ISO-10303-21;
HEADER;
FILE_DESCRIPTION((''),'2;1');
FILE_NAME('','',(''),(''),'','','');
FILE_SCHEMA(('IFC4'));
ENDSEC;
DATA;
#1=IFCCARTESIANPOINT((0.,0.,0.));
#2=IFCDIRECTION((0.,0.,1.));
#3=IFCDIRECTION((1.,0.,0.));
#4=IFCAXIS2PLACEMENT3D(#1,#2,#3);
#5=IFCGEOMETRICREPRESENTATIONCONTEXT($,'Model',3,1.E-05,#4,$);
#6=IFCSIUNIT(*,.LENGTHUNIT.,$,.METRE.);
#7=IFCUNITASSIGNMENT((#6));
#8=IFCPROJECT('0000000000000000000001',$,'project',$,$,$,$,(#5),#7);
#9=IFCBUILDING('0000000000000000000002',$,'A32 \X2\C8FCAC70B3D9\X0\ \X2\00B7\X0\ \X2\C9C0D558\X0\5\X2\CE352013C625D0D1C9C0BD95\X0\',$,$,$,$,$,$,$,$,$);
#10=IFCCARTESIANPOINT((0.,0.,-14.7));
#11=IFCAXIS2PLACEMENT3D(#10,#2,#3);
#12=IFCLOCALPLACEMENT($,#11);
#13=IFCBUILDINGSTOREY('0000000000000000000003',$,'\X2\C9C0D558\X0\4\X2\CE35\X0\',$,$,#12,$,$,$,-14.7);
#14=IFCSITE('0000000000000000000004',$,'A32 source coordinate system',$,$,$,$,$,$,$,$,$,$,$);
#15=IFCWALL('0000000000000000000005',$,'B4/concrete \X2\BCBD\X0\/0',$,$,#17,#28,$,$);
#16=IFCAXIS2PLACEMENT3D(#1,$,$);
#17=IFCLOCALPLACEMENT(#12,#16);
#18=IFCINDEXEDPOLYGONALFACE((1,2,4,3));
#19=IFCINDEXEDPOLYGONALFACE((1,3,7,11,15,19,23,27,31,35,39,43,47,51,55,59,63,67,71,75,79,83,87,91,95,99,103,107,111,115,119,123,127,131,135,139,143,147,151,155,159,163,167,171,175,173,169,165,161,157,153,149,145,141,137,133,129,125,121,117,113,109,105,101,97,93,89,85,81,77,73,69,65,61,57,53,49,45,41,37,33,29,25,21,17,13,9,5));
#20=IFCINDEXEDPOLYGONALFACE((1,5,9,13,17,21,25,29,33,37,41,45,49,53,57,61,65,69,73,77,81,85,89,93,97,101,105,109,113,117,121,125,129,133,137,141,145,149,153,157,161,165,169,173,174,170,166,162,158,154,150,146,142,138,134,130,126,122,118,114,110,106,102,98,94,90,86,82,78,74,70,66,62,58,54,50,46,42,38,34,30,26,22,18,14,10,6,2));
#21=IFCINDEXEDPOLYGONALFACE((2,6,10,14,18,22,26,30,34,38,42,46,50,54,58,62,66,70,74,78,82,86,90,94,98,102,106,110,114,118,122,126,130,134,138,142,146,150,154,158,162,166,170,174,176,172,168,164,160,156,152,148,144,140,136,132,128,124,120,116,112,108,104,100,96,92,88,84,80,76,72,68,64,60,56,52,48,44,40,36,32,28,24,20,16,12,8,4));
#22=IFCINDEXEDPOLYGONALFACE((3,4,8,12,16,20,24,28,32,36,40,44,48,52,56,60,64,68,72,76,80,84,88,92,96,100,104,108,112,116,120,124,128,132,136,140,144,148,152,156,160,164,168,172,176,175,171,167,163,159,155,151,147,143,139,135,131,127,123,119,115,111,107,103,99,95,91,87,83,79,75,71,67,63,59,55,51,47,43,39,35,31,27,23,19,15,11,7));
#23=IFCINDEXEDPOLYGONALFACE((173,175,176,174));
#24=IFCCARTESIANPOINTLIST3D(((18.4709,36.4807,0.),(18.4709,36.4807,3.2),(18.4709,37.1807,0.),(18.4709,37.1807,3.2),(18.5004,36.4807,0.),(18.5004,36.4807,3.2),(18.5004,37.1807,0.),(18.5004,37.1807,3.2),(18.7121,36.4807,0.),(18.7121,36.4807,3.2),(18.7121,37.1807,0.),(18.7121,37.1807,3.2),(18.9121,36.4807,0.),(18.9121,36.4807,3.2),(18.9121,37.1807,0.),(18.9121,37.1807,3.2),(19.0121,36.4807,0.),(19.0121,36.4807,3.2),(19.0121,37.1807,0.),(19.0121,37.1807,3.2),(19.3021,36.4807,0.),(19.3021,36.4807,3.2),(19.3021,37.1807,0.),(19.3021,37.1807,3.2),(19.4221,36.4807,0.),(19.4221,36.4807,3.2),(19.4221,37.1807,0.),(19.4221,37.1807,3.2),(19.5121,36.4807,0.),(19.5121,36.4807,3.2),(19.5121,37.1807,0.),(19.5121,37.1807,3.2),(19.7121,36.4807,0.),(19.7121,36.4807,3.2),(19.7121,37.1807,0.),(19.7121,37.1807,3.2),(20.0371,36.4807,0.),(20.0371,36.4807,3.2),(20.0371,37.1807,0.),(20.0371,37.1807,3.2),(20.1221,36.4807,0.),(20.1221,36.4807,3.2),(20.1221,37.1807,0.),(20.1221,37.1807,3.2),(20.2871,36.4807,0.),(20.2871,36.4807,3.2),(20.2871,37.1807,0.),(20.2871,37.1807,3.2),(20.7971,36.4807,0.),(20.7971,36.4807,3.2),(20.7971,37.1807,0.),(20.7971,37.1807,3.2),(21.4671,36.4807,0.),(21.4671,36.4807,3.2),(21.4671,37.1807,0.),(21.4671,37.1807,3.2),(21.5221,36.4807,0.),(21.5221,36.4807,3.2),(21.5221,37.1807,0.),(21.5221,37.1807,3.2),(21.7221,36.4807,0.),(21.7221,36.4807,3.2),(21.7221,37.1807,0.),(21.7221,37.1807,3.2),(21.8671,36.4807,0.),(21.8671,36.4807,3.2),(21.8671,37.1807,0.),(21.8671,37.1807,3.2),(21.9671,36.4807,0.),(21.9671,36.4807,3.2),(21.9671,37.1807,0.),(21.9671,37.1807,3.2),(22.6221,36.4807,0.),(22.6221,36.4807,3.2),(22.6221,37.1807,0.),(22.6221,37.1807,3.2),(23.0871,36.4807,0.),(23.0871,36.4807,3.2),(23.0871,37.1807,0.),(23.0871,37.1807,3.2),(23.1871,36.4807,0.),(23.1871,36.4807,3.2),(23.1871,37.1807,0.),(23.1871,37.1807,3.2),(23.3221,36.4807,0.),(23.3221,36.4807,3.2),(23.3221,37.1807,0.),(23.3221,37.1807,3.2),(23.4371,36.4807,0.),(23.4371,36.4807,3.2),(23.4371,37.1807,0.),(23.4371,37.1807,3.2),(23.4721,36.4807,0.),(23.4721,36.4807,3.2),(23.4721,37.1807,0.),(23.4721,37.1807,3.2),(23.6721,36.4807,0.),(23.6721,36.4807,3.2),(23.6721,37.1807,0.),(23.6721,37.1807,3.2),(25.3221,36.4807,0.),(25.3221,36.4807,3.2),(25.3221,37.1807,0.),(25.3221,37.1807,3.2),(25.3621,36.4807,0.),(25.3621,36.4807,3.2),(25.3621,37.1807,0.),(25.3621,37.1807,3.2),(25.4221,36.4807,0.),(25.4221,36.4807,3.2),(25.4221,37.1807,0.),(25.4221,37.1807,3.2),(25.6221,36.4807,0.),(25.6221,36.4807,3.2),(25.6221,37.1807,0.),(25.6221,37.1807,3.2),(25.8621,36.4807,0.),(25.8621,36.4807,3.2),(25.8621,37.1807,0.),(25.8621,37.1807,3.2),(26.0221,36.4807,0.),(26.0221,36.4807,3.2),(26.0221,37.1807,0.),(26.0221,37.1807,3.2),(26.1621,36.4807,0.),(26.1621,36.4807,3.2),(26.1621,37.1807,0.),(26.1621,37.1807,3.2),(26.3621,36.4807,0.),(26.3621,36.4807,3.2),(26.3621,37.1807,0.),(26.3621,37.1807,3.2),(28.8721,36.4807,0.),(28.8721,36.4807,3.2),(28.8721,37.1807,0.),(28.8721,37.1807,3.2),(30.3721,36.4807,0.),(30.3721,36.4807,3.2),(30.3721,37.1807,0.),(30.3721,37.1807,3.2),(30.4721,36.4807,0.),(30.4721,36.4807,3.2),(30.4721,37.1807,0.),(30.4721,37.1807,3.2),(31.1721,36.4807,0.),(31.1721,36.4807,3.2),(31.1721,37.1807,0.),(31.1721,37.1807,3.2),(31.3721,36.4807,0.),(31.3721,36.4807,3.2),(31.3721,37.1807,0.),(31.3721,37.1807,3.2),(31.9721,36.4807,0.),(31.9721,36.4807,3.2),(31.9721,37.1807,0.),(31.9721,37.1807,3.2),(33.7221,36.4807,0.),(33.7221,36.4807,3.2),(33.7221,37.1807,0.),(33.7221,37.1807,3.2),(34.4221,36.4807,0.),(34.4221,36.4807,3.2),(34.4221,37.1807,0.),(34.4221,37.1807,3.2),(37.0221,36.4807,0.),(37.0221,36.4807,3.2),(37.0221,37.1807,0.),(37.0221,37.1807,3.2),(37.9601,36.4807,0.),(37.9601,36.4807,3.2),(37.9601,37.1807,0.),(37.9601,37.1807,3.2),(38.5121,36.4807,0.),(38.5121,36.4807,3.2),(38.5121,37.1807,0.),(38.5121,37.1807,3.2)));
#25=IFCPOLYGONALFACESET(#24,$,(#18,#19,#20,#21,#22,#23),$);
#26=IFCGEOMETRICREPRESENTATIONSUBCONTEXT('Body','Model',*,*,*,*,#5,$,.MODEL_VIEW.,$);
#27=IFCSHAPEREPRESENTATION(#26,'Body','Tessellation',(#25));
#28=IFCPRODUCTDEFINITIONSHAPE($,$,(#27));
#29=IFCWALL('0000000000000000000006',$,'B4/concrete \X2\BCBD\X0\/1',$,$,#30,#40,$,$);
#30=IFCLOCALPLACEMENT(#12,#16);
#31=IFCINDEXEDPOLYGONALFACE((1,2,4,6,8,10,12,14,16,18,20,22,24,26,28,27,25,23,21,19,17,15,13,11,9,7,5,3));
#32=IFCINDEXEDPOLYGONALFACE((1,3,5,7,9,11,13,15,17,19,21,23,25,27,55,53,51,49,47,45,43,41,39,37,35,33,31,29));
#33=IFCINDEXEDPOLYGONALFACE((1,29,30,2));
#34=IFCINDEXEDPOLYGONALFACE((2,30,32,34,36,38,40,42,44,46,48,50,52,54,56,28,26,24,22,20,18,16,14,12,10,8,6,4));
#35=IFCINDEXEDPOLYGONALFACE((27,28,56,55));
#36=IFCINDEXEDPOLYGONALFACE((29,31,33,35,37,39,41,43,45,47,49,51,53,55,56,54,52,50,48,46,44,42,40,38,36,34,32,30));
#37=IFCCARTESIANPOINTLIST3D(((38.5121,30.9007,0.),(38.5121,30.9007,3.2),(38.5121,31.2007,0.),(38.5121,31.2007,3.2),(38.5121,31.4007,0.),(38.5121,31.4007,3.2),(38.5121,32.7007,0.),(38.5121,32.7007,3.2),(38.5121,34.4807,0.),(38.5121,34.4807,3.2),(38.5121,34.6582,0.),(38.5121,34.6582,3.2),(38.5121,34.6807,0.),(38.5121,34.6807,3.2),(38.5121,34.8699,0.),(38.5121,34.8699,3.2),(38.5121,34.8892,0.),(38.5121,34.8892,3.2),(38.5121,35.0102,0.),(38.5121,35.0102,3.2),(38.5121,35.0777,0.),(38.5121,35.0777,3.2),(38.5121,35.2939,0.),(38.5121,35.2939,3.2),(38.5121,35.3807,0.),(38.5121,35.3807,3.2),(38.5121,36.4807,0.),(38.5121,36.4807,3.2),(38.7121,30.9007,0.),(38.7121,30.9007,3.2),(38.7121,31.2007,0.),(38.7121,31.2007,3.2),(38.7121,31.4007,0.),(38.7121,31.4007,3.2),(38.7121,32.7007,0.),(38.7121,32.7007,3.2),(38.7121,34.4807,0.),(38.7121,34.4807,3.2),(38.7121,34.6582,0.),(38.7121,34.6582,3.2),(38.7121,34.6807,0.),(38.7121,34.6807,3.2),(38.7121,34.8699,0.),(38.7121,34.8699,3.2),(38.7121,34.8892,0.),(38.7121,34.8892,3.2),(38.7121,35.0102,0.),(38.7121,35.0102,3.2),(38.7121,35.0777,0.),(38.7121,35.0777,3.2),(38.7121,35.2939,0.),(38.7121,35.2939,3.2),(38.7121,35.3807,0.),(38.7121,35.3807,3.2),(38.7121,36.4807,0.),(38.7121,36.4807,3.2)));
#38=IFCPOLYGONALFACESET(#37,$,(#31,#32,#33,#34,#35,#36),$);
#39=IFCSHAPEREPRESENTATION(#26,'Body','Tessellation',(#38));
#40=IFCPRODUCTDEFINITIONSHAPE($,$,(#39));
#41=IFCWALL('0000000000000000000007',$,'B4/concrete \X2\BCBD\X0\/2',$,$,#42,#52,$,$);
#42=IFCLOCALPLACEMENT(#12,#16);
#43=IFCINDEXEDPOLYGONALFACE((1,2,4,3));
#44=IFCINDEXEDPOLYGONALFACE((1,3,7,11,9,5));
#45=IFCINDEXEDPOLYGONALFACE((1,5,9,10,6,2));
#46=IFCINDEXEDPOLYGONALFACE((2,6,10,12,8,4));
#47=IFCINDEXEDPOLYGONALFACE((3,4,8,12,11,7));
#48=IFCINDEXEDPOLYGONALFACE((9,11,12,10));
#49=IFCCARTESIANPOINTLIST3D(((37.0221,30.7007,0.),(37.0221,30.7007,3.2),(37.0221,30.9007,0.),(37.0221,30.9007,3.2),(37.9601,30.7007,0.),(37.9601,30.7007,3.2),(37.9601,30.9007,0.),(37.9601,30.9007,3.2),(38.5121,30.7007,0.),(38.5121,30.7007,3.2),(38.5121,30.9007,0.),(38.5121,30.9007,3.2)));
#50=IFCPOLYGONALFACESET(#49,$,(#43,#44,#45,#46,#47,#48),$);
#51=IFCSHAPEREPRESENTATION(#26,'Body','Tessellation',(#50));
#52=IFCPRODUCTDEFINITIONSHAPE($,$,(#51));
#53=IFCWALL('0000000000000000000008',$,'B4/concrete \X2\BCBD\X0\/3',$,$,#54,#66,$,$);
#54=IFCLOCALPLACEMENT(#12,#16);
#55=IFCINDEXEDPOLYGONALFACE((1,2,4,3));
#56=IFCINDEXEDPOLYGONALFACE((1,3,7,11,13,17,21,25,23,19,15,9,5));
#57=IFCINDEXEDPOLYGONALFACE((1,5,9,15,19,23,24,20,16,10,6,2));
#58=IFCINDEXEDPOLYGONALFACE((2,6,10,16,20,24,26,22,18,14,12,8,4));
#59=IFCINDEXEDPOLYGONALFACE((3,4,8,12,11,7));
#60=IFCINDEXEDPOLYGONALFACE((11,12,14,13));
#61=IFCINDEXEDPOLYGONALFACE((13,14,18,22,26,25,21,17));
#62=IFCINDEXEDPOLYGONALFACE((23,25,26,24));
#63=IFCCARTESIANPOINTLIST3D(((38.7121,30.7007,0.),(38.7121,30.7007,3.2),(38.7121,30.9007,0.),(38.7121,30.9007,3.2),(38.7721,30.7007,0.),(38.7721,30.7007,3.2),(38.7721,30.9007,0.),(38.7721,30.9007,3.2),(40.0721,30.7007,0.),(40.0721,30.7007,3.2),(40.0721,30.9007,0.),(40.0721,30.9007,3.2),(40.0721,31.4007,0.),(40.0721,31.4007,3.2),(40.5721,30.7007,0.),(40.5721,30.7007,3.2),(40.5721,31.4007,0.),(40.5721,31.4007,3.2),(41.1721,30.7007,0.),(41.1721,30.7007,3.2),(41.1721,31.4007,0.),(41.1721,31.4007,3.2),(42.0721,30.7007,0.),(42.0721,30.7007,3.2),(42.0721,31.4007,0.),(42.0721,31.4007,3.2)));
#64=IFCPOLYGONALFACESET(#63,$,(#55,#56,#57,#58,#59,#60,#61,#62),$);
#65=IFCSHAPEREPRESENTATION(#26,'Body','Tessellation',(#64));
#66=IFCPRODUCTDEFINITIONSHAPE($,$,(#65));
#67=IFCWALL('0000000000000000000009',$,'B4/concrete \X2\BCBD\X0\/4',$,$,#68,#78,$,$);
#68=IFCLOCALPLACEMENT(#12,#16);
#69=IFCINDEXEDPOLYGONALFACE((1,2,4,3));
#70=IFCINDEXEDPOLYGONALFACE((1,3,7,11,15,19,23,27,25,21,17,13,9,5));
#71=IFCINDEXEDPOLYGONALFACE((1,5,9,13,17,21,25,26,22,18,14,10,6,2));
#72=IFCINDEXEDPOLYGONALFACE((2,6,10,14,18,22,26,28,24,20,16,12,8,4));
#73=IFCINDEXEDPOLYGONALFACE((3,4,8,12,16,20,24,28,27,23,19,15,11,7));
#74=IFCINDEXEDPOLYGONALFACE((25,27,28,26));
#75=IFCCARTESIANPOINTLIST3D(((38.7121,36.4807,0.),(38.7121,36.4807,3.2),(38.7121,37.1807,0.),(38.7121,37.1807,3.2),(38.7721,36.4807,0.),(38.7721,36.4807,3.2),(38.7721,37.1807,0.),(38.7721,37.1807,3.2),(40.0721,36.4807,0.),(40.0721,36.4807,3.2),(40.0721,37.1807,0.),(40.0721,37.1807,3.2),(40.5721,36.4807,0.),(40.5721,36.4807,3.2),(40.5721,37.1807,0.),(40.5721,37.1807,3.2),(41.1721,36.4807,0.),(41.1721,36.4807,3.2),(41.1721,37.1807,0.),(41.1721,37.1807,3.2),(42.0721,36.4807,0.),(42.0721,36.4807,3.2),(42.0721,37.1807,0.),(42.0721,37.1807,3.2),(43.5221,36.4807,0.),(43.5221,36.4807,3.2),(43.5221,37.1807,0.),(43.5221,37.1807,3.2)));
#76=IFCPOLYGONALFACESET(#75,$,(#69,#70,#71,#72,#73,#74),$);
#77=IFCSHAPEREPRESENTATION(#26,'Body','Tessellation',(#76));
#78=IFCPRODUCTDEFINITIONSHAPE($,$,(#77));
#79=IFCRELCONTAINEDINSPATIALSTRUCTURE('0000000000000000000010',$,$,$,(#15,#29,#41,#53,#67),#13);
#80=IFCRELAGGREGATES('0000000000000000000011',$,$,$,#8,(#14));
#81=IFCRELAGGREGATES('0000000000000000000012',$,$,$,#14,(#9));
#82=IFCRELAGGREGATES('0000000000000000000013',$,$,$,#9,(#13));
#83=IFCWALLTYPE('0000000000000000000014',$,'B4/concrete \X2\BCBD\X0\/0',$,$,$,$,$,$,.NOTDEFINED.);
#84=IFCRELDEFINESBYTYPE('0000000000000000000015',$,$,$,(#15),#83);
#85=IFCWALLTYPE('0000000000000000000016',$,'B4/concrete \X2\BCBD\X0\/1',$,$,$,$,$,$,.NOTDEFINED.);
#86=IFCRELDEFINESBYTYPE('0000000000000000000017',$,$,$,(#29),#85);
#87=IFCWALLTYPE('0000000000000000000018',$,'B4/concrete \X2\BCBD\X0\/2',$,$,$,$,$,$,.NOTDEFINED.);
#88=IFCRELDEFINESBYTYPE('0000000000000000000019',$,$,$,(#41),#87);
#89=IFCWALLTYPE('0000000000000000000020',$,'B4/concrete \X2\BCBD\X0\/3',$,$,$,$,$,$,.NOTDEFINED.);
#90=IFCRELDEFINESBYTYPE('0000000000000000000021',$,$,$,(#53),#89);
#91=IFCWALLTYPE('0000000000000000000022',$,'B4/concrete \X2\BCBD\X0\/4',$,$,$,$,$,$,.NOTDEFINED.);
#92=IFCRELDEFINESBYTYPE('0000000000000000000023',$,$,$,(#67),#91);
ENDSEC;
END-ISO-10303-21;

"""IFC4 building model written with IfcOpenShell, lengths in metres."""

from ifc_helpers import new_model, si_unit, frame, origin, origin_with_axes, place, context, subcontext, project, spatial, polyline, outline, extrude, source, transform, mapped, type_object, type_shapes, element, save


model = new_model("IFC4")

# Units and contexts
model_context = context("Model", 3, precision=1e-05, world=origin_with_axes())
body_context = subcontext(model_context, "Body", "Model", "MODEL_VIEW")
ifc_project = project(units=[si_unit("LENGTHUNIT", "METRE")], contexts=[model_context])

# Site, building, storey
site = spatial("IfcSite", under=ifc_project, Name="A32 source coordinate system")
building = spatial("IfcBuilding", under=site, Name="A32 주거동 · 지하5층–옥탑지붕")
storey_placement = place(None, frame((0.0, 0.0, -14.7), z_axis=(0.0, 0.0, 1.0), x_axis=(1.0, 0.0, 0.0)))
storey = spatial("IfcBuildingStorey", under=building, at=storey_placement, Name="지하4층", Elevation=-14.7)

# Walls
wall_type_1 = type_object("IfcWallType", Name="B4/concrete 벽/0", PredefinedType="NOTDEFINED")
shared_shape_1 = source(origin(), body_context, "Body", "SweptSolid", [
    extrude(outline(polyline([(18.5004, 36.4807), (18.4709, 36.4807), (18.4709, 37.1807), (18.5004, 37.1807), (18.7121, 37.1807), (18.9121, 37.1807), (19.0121, 37.1807), (19.3021, 37.1807), (19.4221, 37.1807), (19.5121, 37.1807), (19.7121, 37.1807), (20.0371, 37.1807), (20.1221, 37.1807), (20.2871, 37.1807), (20.7971, 37.1807), (21.4671, 37.1807), (21.5221, 37.1807), (21.7221, 37.1807), (21.8671, 37.1807), (21.9671, 37.1807), (22.6221, 37.1807), (23.0871, 37.1807), (23.1871, 37.1807), (23.3221, 37.1807), (23.4371, 37.1807), (23.4721, 37.1807), (23.6721, 37.1807), (25.3221, 37.1807), (25.3621, 37.1807), (25.4221, 37.1807), (25.6221, 37.1807), (25.8621, 37.1807), (26.0221, 37.1807), (26.1621, 37.1807), (26.3621, 37.1807), (28.8721, 37.1807), (30.3721, 37.1807), (30.4721, 37.1807), (31.1721, 37.1807), (31.3721, 37.1807), (31.9721, 37.1807), (33.7221, 37.1807), (34.4221, 37.1807), (37.0221, 37.1807), (37.9601, 37.1807), (38.5121, 37.1807), (38.5121, 36.4807), (37.9601, 36.4807), (37.0221, 36.4807), (34.4221, 36.4807), (33.7221, 36.4807), (31.9721, 36.4807), (31.3721, 36.4807), (31.1721, 36.4807), (30.4721, 36.4807), (30.3721, 36.4807), (28.8721, 36.4807), (26.3621, 36.4807), (26.1621, 36.4807), (26.0221, 36.4807), (25.8621, 36.4807), (25.6221, 36.4807), (25.4221, 36.4807), (25.3621, 36.4807), (25.3221, 36.4807), (23.6721, 36.4807), (23.4721, 36.4807), (23.4371, 36.4807), (23.3221, 36.4807), (23.1871, 36.4807), (23.0871, 36.4807), (22.6221, 36.4807), (21.9671, 36.4807), (21.8671, 36.4807), (21.7221, 36.4807), (21.5221, 36.4807), (21.4671, 36.4807), (20.7971, 36.4807), (20.2871, 36.4807), (20.1221, 36.4807), (20.0371, 36.4807), (19.7121, 36.4807), (19.5121, 36.4807), (19.4221, 36.4807), (19.3021, 36.4807), (19.0121, 36.4807), (18.9121, 36.4807), (18.7121, 36.4807), (18.5004, 36.4807)])), origin(), (0.0, 0.0, 1.0), 3.2),
])
type_shapes(wall_type_1, [shared_shape_1])
wall_1_placement = place(storey_placement, origin_with_axes())
element("IfcWall", 1, at=wall_1_placement, inside=storey, type_object=wall_type_1, Name="B4/concrete 벽/0", context=body_context, shape_type="MappedRepresentation", body=[
    mapped(shared_shape_1, transform((0.0, 0.0, 0.0), scale=1.0)),
])
wall_type_2 = type_object("IfcWallType", Name="B4/concrete 벽/1", PredefinedType="NOTDEFINED")
shared_shape_2 = source(origin(), body_context, "Body", "SweptSolid", [
    extrude(outline(polyline([(38.7121, 35.2939), (38.7121, 35.0777), (38.7121, 35.0102), (38.7121, 34.8892), (38.7121, 34.8699), (38.7121, 34.6807), (38.7121, 34.6582), (38.7121, 34.4807), (38.7121, 32.7007), (38.7121, 31.4007), (38.7121, 31.2007), (38.7121, 30.9007), (38.5121, 30.9007), (38.5121, 31.2007), (38.5121, 31.4007), (38.5121, 32.7007), (38.5121, 34.4807), (38.5121, 34.6582), (38.5121, 34.6807), (38.5121, 34.8699), (38.5121, 34.8892), (38.5121, 35.0102), (38.5121, 35.0777), (38.5121, 35.2939), (38.5121, 35.3807), (38.5121, 36.4807), (38.7121, 36.4807), (38.7121, 35.3807), (38.7121, 35.2939)])), origin(), (0.0, 0.0, 1.0), 3.2),
])
type_shapes(wall_type_2, [shared_shape_2])
wall_2_placement = place(storey_placement, origin_with_axes())
element("IfcWall", 2, at=wall_2_placement, inside=storey, type_object=wall_type_2, Name="B4/concrete 벽/1", context=body_context, shape_type="MappedRepresentation", body=[
    mapped(shared_shape_2, transform((0.0, 0.0, 0.0), scale=1.0)),
])
wall_type_3 = type_object("IfcWallType", Name="B4/concrete 벽/2", PredefinedType="NOTDEFINED")
shared_shape_3 = source(origin(), body_context, "Body", "SweptSolid", [
    extrude(outline(polyline([(37.0221, 30.7007), (37.0221, 30.9007), (37.9601, 30.9007), (38.5121, 30.9007), (38.5121, 30.7007), (37.9601, 30.7007), (37.0221, 30.7007)])), origin(), (0.0, 0.0, 1.0), 3.2),
])
type_shapes(wall_type_3, [shared_shape_3])
wall_3_placement = place(storey_placement, origin_with_axes())
element("IfcWall", 3, at=wall_3_placement, inside=storey, type_object=wall_type_3, Name="B4/concrete 벽/2", context=body_context, shape_type="MappedRepresentation", body=[
    mapped(shared_shape_3, transform((0.0, 0.0, 0.0), scale=1.0)),
])
wall_type_4 = type_object("IfcWallType", Name="B4/concrete 벽/3", PredefinedType="NOTDEFINED")
shared_shape_4 = source(origin(), body_context, "Body", "SweptSolid", [
    extrude(outline(polyline([(40.0721, 31.4007), (40.5721, 31.4007), (41.1721, 31.4007), (42.0721, 31.4007), (42.0721, 30.7007), (41.1721, 30.7007), (40.5721, 30.7007), (40.0721, 30.7007), (38.7721, 30.7007), (38.7121, 30.7007), (38.7121, 30.9007), (38.7721, 30.9007), (40.0721, 30.9007), (40.0721, 31.4007)])), origin(), (0.0, 0.0, 1.0), 3.2),
])
type_shapes(wall_type_4, [shared_shape_4])
wall_4_placement = place(storey_placement, origin_with_axes())
element("IfcWall", 4, at=wall_4_placement, inside=storey, type_object=wall_type_4, Name="B4/concrete 벽/3", context=body_context, shape_type="MappedRepresentation", body=[
    mapped(shared_shape_4, transform((0.0, 0.0, 0.0), scale=1.0)),
])
wall_type_5 = type_object("IfcWallType", Name="B4/concrete 벽/4", PredefinedType="NOTDEFINED")
shared_shape_5 = source(origin(), body_context, "Body", "SweptSolid", [
    extrude(outline(polyline([(40.0721, 37.1807), (40.5721, 37.1807), (41.1721, 37.1807), (42.0721, 37.1807), (43.5221, 37.1807), (43.5221, 36.4807), (42.0721, 36.4807), (41.1721, 36.4807), (40.5721, 36.4807), (40.0721, 36.4807), (38.7721, 36.4807), (38.7121, 36.4807), (38.7121, 37.1807), (38.7721, 37.1807), (40.0721, 37.1807)])), origin(), (0.0, 0.0, 1.0), 3.2),
])
type_shapes(wall_type_5, [shared_shape_5])
wall_5_placement = place(storey_placement, origin_with_axes())
element("IfcWall", 5, at=wall_5_placement, inside=storey, type_object=wall_type_5, Name="B4/concrete 벽/4", context=body_context, shape_type="MappedRepresentation", body=[
    mapped(shared_shape_5, transform((0.0, 0.0, 0.0), scale=1.0)),
])

save(model, "model.ifc")
